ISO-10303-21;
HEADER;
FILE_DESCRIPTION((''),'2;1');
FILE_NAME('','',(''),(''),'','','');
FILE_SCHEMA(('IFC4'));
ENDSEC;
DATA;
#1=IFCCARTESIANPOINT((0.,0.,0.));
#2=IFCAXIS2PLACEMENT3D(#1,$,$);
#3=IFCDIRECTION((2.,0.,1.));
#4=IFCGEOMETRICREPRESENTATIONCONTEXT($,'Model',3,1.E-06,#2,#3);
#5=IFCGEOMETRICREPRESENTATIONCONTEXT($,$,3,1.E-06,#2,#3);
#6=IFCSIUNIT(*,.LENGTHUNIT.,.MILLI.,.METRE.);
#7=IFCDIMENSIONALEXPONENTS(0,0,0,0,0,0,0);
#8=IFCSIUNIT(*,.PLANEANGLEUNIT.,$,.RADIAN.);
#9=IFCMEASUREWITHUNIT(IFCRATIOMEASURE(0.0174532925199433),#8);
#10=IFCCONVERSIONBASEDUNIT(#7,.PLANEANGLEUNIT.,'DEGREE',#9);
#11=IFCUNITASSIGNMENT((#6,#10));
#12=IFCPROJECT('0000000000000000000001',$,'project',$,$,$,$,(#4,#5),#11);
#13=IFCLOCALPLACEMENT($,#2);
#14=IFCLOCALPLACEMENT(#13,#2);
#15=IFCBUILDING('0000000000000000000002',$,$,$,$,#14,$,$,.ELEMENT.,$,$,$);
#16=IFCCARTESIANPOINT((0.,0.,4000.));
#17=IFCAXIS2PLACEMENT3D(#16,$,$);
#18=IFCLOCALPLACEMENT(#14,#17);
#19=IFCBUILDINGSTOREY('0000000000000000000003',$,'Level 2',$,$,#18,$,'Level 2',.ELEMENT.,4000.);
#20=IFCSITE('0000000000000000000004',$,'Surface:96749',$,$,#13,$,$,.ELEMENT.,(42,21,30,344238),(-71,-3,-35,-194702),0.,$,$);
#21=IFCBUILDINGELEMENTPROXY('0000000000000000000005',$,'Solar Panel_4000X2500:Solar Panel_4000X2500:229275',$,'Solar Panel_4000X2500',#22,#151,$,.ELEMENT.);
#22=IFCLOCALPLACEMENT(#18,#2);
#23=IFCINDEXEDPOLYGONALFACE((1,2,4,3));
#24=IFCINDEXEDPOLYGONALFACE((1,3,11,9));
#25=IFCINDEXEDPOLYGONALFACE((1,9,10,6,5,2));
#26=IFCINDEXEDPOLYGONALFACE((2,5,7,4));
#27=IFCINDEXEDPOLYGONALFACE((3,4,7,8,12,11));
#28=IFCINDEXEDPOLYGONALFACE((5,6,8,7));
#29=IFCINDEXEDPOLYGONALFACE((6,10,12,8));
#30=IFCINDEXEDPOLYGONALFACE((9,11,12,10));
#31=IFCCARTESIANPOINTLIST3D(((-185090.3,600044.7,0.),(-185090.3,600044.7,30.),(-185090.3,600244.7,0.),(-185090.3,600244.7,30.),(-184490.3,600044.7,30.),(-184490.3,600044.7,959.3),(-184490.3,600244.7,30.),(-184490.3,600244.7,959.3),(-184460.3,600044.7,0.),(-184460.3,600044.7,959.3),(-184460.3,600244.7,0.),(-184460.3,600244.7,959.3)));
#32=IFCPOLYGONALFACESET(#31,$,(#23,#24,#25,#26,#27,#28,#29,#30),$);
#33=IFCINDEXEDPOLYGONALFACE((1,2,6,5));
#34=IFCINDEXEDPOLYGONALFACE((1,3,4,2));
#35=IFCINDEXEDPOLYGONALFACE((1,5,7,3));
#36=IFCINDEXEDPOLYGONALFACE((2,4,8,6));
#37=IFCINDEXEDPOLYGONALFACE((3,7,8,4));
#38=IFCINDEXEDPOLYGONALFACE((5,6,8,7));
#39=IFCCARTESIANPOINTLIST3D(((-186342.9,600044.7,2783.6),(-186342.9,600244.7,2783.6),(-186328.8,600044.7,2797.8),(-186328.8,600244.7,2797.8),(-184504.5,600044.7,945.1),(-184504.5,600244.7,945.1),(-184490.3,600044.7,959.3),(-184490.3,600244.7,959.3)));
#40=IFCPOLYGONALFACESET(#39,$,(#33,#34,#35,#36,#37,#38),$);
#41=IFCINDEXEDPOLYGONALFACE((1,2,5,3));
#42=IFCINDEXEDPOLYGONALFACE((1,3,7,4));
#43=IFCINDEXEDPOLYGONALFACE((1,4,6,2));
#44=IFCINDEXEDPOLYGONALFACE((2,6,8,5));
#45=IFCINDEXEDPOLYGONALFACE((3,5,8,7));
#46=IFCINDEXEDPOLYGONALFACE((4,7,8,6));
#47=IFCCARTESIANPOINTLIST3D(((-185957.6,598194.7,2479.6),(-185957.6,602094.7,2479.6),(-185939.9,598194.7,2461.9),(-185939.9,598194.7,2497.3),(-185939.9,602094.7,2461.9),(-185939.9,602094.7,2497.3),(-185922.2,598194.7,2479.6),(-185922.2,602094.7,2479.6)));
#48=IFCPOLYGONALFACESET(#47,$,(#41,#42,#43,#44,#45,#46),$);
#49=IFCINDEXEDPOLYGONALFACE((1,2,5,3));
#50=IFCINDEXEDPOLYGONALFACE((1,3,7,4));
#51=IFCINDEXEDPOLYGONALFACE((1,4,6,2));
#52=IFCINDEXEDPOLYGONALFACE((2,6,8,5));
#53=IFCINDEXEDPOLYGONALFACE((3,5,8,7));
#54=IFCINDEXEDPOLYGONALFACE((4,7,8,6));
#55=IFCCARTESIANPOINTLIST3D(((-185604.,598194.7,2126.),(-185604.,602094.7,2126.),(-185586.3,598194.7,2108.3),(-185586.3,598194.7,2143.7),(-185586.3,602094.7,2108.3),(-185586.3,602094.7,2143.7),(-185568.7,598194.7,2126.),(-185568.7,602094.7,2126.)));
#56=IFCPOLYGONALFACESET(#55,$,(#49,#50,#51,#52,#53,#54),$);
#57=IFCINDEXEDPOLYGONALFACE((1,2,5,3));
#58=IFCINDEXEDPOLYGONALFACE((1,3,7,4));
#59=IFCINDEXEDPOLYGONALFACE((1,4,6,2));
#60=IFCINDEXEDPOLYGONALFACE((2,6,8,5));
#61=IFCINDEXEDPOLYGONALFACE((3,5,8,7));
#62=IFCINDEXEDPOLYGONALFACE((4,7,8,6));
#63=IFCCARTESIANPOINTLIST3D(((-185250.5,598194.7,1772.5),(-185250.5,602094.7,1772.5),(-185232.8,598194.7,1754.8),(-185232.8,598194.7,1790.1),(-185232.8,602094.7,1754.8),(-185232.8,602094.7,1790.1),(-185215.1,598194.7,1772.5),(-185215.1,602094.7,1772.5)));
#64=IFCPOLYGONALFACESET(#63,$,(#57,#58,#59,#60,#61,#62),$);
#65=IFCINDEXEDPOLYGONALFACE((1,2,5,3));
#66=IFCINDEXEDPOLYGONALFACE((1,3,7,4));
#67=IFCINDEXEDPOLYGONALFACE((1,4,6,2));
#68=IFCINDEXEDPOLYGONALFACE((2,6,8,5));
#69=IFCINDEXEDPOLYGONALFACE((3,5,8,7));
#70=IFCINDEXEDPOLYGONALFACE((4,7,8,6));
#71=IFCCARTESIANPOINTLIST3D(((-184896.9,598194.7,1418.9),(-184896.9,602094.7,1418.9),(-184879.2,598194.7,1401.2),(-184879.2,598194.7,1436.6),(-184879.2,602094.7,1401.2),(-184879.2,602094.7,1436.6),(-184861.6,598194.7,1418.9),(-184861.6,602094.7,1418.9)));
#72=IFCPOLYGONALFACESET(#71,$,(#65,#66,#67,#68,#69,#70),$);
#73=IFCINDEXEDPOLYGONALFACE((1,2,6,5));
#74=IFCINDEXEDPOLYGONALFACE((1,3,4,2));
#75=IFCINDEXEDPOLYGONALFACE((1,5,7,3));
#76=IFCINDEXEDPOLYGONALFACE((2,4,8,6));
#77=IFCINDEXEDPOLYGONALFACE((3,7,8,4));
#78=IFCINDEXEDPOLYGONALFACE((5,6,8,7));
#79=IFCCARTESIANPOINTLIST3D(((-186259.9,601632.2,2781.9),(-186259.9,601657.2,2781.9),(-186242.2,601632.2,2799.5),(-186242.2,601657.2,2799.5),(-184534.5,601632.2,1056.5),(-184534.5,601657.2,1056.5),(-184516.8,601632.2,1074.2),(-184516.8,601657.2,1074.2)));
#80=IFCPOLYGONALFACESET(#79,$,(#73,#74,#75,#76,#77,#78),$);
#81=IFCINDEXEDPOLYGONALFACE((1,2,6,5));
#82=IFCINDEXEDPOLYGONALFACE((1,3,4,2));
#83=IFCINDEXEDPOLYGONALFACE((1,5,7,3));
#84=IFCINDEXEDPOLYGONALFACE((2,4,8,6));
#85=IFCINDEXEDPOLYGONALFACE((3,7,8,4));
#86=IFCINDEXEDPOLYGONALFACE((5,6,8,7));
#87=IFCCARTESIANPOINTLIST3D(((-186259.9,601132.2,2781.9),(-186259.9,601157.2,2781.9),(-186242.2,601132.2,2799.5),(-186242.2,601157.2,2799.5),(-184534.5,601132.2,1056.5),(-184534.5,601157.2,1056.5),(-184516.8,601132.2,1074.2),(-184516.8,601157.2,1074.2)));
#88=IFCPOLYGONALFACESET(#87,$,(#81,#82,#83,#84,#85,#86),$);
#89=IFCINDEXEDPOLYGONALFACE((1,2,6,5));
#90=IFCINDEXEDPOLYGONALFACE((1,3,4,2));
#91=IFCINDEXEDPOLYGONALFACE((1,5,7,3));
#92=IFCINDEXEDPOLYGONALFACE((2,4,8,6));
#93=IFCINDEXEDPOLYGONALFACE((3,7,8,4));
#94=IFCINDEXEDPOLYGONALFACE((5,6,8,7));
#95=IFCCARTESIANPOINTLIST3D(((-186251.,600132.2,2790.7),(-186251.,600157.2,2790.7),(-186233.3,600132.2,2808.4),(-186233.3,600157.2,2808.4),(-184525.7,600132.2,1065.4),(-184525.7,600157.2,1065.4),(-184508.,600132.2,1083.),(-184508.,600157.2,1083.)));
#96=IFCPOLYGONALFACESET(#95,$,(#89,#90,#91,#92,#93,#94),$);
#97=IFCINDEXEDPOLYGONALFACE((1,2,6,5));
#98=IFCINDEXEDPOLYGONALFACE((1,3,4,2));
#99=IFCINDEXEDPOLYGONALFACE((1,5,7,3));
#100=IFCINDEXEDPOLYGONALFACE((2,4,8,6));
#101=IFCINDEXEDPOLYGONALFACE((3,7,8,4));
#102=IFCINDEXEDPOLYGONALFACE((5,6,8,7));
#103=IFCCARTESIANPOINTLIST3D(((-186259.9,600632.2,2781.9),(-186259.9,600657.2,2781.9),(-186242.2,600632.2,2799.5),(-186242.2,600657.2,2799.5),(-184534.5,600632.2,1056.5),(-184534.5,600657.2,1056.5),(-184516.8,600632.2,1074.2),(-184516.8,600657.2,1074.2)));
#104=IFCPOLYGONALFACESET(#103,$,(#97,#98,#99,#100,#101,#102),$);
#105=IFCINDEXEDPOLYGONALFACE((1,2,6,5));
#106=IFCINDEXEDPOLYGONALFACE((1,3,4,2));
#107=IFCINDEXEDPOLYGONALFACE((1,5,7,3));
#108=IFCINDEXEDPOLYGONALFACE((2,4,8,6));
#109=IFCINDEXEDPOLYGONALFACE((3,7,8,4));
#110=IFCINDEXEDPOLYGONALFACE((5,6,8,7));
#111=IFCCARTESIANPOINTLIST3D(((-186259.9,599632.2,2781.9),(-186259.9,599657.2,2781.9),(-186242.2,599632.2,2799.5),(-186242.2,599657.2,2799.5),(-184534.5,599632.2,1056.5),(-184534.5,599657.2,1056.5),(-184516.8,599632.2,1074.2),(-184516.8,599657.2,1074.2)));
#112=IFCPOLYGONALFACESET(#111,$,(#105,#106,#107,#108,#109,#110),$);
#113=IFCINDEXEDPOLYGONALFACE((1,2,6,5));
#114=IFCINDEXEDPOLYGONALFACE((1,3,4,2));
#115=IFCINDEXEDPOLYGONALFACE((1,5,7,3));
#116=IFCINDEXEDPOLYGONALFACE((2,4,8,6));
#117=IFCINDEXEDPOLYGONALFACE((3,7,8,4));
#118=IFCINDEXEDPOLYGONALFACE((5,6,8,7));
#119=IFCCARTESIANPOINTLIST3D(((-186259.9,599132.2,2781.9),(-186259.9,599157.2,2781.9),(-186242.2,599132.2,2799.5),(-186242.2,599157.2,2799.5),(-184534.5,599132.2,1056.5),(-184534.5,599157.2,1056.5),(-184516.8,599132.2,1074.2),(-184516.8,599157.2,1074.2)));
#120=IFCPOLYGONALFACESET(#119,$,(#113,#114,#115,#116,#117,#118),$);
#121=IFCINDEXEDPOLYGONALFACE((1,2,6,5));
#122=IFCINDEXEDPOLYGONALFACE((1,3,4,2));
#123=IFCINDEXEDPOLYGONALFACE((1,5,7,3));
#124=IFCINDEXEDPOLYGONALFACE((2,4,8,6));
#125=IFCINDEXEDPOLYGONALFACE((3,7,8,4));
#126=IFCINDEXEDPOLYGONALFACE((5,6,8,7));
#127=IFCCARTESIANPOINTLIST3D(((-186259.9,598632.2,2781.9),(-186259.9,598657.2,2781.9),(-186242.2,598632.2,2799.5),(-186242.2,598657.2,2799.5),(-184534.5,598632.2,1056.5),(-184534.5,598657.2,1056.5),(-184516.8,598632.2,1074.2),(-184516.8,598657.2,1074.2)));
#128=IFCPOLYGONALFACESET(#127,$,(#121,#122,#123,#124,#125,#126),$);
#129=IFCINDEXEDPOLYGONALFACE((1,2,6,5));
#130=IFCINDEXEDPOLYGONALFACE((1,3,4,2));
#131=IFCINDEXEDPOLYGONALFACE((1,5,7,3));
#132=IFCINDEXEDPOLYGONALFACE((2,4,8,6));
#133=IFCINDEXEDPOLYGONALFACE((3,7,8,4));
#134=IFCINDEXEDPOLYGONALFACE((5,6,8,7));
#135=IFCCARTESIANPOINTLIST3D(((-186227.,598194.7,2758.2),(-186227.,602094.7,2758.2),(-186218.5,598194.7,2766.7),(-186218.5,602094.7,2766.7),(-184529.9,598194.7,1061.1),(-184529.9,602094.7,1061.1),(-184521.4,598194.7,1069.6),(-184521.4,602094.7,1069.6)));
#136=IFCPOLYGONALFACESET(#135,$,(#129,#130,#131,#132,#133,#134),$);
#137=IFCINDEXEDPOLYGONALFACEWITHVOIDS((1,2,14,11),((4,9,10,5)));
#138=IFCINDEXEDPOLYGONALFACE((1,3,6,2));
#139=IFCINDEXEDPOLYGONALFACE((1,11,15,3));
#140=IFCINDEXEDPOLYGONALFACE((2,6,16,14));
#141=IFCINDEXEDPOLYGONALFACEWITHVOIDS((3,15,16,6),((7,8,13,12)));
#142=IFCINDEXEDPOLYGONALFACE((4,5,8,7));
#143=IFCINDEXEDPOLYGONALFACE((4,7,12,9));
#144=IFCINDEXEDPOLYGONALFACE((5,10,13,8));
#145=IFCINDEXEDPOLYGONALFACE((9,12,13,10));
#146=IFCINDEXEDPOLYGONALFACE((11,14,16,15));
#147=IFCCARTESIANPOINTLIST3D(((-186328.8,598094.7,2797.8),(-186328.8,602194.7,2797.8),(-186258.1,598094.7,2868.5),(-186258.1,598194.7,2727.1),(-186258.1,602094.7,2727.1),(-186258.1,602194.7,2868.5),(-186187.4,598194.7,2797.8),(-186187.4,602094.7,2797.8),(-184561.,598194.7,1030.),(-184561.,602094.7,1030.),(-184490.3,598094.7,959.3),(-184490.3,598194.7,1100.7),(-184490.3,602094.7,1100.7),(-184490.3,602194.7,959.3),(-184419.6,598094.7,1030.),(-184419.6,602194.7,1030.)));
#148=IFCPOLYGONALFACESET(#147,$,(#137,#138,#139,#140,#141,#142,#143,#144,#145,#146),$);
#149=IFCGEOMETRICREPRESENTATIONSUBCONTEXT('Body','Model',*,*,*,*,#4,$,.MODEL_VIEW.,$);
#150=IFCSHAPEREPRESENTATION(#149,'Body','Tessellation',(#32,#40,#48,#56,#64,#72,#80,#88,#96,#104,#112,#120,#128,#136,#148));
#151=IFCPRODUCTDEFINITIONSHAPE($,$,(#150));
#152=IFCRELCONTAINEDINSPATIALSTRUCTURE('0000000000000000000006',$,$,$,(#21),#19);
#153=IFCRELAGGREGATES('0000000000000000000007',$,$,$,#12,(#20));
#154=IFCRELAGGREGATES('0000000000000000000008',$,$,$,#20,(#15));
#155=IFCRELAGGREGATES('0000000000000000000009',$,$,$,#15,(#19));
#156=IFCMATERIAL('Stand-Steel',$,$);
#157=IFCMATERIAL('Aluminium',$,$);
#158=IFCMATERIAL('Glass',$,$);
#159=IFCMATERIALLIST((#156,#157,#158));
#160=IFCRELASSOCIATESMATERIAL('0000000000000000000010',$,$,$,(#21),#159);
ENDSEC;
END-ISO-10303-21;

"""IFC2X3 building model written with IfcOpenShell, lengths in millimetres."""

from ifc_helpers import new_model, entity, si_unit, converted_unit, direction, frame, frame_2d, origin, origin_2d_with_axis, place, context, subcontext, project, spatial, polyline, rectangle, outline, extrude, source, transform, mapped, material, material_list, element, save


model = new_model("IFC2X3")

# Units and contexts
model_context = context("Model", 3, precision=1e-06, world=origin(), true_north=direction((2.0, 0.0, 1.0)))
context_of_model = context(None, 3, precision=1e-06, world=origin(), true_north=direction((2.0, 0.0, 1.0)))
body_context = subcontext(model_context, "Body", "Model", "MODEL_VIEW")
ifc_project = project(units=[si_unit("LENGTHUNIT", "METRE", prefix="MILLI"), converted_unit("PLANEANGLEUNIT", "DEGREE", entity("IfcRatioMeasure", 0.0174532925199433), si_unit("PLANEANGLEUNIT", "RADIAN"), dimensions=[0, 0, 0, 0, 0, 0, 0])], contexts=[model_context, context_of_model])

# Site, building, storey
site_placement = place(None, origin())
site = spatial("IfcSite", under=ifc_project, at=site_placement, Name="Surface:96749", CompositionType="ELEMENT", RefLatitude=(42, 21, 30, 344238), RefLongitude=(-71, -3, -35, -194702), RefElevation=0.0)
building_placement = place(site_placement, origin())
building = spatial("IfcBuilding", under=site, at=building_placement, CompositionType="ELEMENT")
storey_placement = place(building_placement, frame((0.0, 0.0, 4000.0)))
storey = spatial("IfcBuildingStorey", under=building, at=storey_placement, Name="Level 2", LongName="Level 2", CompositionType="ELEMENT", Elevation=4000.0)

# Building element proxy
ifc_material_1 = material(Name="Stand-Steel")
ifc_material_2 = material(Name="Aluminium")
ifc_material_3 = material(Name="Glass")
shared_shape = source(origin(), body_context, "Body", "SweptSolid", [
    extrude(outline(polyline([(-629.5, -220.0), (329.8, -220.0), (329.8, 410.0), (299.8, 410.0), (299.8, -190.0), (-629.5, -190.0), (-629.5, -220.0)])), frame((-190.0, -100.0, 299.8), z_axis=(0.0, 1.0, 0.0), x_axis=(0.0, 0.0, -1.0)), (0.0, 0.0, 1.0), 200.0),
    extrude(rectangle(XDim=20.0, YDim=200.0, at=frame_2d((0.0, 0.0), x_axis=(0.0, 1.0))), frame((-7.1, 0.0, 922.2), z_axis=(-0.707107, 0.0, 0.707107), x_axis=(0.0, 1.0, 0.0)), (0.0, 0.0, 1.0), 2600.0),
    extrude(rectangle(XDim=25.0, YDim=25.0, at=frame_2d((0.0, 0.0), x_axis=(1.0, 0.0))), frame((-1449.6, -1950.0, 2449.6), z_axis=(0.0, 1.0, 0.0), x_axis=(-0.707107, 0.0, -0.707107)), (0.0, 0.0, 1.0), 3900.0),
    extrude(rectangle(XDim=25.0, YDim=25.0, at=origin_2d_with_axis()), frame((-1096.0, -1950.0, 2096.0), z_axis=(0.0, 1.0, 0.0), x_axis=(-0.707107, 0.0, -0.707107)), (0.0, 0.0, 1.0), 3900.0),
    extrude(rectangle(XDim=25.0, YDim=25.0, at=origin_2d_with_axis()), frame((-742.5, -1950.0, 1742.5), z_axis=(0.0, 1.0, 0.0), x_axis=(-0.707107, 0.0, -0.707107)), (0.0, 0.0, 1.0), 3900.0),
    extrude(rectangle(XDim=25.0, YDim=25.0, at=frame_2d((0.0, 0.0), x_axis=(1.0, 0.0))), frame((-388.9, -1950.0, 1388.9), z_axis=(0.0, 1.0, 0.0), x_axis=(-0.707107, 0.0, -0.707107)), (0.0, 0.0, 1.0), 3900.0),
    extrude(rectangle(XDim=25.0, YDim=25.0, at=frame_2d((0.0, 0.0), x_axis=(0.0, 1.0))), frame((-35.4, 1500.0, 1035.4), z_axis=(-0.707107, 0.0, 0.707107), x_axis=(0.0, 1.0, 0.0)), (0.0, 0.0, 1.0), 2440.0),
    extrude(rectangle(XDim=25.0, YDim=25.0, at=frame_2d((0.0, 0.0), x_axis=(0.0, 1.0))), frame((-35.4, 1000.0, 1035.4), z_axis=(-0.707107, 0.0, 0.707107), x_axis=(0.0, 1.0, 0.0)), (0.0, 0.0, 1.0), 2440.0),
    extrude(rectangle(XDim=25.0, YDim=25.0, at=frame_2d((0.0, 0.0), x_axis=(0.0, 1.0))), frame((-26.5, 0.0, 1044.2), z_axis=(-0.707107, 0.0, 0.707107), x_axis=(0.0, -1.0, 0.0)), (0.0, 0.0, 1.0), 2440.0),
    extrude(rectangle(XDim=25.0, YDim=25.0, at=frame_2d((0.0, 0.0), x_axis=(0.0, 1.0))), frame((-35.4, 500.0, 1035.4), z_axis=(-0.707107, 0.0, 0.707107), x_axis=(0.0, 1.0, 0.0)), (0.0, 0.0, 1.0), 2440.0),
    extrude(rectangle(XDim=25.0, YDim=25.0, at=frame_2d((0.0, 0.0), x_axis=(0.0, 1.0))), frame((-35.4, -500.0, 1035.4), z_axis=(-0.707107, 0.0, 0.707107), x_axis=(0.0, 1.0, 0.0)), (0.0, 0.0, 1.0), 2440.0),
    extrude(rectangle(XDim=25.0, YDim=25.0, at=frame_2d((0.0, 0.0), x_axis=(0.0, 1.0))), frame((-35.4, -1000.0, 1035.4), z_axis=(-0.707107, 0.0, 0.707107), x_axis=(0.0, 1.0, 0.0)), (0.0, 0.0, 1.0), 2440.0),
    extrude(rectangle(XDim=25.0, YDim=25.0, at=frame_2d((0.0, 0.0), x_axis=(0.0, 1.0))), frame((-35.4, -1500.0, 1035.4), z_axis=(-0.707107, 0.0, 0.707107), x_axis=(0.0, 1.0, 0.0)), (0.0, 0.0, 1.0), 2440.0),
    extrude(rectangle(XDim=2400.0, YDim=12.0, at=frame_2d((0.0, 0.0), x_axis=(1.0, 0.0))), frame((-883.9, -1950.0, 1883.9), z_axis=(0.0, 1.0, 0.0), x_axis=(0.707107, 0.0, -0.707107)), (0.0, 0.0, 1.0), 3900.0),
    extrude(outline(polyline([(-2050.0, -1300.0), (2050.0, -1300.0), (2050.0, 1300.0), (-2050.0, 1300.0), (-2050.0, -1300.0)]), holes=[polyline([(1950.0, -1200.0), (-1950.0, -1200.0), (-1950.0, 1200.0), (1950.0, 1200.0), (1950.0, -1200.0)])]), frame((-919.2, 0.0, 1848.5), z_axis=(0.707107, 0.0, 0.707107), x_axis=(0.0, 1.0, 0.0)), (0.0, 0.0, 1.0), 100.0),
])
ifc_material_list_1 = material_list([ifc_material_1, ifc_material_2, ifc_material_3])
proxy_1_placement = place(storey_placement, frame((-184490.3, 600144.7, 30.0)))
element("IfcBuildingElementProxy", 1, at=proxy_1_placement, inside=storey, material=ifc_material_list_1, Name="Solar Panel_4000X2500:Solar Panel_4000X2500:229275", ObjectType="Solar Panel_4000X2500", CompositionType="ELEMENT", context=body_context, shape_type="MappedRepresentation", body=[
    mapped(shared_shape, transform((0.0, 0.0, 0.0), scale=1.0)),
])

save(model, "model.ifc")
